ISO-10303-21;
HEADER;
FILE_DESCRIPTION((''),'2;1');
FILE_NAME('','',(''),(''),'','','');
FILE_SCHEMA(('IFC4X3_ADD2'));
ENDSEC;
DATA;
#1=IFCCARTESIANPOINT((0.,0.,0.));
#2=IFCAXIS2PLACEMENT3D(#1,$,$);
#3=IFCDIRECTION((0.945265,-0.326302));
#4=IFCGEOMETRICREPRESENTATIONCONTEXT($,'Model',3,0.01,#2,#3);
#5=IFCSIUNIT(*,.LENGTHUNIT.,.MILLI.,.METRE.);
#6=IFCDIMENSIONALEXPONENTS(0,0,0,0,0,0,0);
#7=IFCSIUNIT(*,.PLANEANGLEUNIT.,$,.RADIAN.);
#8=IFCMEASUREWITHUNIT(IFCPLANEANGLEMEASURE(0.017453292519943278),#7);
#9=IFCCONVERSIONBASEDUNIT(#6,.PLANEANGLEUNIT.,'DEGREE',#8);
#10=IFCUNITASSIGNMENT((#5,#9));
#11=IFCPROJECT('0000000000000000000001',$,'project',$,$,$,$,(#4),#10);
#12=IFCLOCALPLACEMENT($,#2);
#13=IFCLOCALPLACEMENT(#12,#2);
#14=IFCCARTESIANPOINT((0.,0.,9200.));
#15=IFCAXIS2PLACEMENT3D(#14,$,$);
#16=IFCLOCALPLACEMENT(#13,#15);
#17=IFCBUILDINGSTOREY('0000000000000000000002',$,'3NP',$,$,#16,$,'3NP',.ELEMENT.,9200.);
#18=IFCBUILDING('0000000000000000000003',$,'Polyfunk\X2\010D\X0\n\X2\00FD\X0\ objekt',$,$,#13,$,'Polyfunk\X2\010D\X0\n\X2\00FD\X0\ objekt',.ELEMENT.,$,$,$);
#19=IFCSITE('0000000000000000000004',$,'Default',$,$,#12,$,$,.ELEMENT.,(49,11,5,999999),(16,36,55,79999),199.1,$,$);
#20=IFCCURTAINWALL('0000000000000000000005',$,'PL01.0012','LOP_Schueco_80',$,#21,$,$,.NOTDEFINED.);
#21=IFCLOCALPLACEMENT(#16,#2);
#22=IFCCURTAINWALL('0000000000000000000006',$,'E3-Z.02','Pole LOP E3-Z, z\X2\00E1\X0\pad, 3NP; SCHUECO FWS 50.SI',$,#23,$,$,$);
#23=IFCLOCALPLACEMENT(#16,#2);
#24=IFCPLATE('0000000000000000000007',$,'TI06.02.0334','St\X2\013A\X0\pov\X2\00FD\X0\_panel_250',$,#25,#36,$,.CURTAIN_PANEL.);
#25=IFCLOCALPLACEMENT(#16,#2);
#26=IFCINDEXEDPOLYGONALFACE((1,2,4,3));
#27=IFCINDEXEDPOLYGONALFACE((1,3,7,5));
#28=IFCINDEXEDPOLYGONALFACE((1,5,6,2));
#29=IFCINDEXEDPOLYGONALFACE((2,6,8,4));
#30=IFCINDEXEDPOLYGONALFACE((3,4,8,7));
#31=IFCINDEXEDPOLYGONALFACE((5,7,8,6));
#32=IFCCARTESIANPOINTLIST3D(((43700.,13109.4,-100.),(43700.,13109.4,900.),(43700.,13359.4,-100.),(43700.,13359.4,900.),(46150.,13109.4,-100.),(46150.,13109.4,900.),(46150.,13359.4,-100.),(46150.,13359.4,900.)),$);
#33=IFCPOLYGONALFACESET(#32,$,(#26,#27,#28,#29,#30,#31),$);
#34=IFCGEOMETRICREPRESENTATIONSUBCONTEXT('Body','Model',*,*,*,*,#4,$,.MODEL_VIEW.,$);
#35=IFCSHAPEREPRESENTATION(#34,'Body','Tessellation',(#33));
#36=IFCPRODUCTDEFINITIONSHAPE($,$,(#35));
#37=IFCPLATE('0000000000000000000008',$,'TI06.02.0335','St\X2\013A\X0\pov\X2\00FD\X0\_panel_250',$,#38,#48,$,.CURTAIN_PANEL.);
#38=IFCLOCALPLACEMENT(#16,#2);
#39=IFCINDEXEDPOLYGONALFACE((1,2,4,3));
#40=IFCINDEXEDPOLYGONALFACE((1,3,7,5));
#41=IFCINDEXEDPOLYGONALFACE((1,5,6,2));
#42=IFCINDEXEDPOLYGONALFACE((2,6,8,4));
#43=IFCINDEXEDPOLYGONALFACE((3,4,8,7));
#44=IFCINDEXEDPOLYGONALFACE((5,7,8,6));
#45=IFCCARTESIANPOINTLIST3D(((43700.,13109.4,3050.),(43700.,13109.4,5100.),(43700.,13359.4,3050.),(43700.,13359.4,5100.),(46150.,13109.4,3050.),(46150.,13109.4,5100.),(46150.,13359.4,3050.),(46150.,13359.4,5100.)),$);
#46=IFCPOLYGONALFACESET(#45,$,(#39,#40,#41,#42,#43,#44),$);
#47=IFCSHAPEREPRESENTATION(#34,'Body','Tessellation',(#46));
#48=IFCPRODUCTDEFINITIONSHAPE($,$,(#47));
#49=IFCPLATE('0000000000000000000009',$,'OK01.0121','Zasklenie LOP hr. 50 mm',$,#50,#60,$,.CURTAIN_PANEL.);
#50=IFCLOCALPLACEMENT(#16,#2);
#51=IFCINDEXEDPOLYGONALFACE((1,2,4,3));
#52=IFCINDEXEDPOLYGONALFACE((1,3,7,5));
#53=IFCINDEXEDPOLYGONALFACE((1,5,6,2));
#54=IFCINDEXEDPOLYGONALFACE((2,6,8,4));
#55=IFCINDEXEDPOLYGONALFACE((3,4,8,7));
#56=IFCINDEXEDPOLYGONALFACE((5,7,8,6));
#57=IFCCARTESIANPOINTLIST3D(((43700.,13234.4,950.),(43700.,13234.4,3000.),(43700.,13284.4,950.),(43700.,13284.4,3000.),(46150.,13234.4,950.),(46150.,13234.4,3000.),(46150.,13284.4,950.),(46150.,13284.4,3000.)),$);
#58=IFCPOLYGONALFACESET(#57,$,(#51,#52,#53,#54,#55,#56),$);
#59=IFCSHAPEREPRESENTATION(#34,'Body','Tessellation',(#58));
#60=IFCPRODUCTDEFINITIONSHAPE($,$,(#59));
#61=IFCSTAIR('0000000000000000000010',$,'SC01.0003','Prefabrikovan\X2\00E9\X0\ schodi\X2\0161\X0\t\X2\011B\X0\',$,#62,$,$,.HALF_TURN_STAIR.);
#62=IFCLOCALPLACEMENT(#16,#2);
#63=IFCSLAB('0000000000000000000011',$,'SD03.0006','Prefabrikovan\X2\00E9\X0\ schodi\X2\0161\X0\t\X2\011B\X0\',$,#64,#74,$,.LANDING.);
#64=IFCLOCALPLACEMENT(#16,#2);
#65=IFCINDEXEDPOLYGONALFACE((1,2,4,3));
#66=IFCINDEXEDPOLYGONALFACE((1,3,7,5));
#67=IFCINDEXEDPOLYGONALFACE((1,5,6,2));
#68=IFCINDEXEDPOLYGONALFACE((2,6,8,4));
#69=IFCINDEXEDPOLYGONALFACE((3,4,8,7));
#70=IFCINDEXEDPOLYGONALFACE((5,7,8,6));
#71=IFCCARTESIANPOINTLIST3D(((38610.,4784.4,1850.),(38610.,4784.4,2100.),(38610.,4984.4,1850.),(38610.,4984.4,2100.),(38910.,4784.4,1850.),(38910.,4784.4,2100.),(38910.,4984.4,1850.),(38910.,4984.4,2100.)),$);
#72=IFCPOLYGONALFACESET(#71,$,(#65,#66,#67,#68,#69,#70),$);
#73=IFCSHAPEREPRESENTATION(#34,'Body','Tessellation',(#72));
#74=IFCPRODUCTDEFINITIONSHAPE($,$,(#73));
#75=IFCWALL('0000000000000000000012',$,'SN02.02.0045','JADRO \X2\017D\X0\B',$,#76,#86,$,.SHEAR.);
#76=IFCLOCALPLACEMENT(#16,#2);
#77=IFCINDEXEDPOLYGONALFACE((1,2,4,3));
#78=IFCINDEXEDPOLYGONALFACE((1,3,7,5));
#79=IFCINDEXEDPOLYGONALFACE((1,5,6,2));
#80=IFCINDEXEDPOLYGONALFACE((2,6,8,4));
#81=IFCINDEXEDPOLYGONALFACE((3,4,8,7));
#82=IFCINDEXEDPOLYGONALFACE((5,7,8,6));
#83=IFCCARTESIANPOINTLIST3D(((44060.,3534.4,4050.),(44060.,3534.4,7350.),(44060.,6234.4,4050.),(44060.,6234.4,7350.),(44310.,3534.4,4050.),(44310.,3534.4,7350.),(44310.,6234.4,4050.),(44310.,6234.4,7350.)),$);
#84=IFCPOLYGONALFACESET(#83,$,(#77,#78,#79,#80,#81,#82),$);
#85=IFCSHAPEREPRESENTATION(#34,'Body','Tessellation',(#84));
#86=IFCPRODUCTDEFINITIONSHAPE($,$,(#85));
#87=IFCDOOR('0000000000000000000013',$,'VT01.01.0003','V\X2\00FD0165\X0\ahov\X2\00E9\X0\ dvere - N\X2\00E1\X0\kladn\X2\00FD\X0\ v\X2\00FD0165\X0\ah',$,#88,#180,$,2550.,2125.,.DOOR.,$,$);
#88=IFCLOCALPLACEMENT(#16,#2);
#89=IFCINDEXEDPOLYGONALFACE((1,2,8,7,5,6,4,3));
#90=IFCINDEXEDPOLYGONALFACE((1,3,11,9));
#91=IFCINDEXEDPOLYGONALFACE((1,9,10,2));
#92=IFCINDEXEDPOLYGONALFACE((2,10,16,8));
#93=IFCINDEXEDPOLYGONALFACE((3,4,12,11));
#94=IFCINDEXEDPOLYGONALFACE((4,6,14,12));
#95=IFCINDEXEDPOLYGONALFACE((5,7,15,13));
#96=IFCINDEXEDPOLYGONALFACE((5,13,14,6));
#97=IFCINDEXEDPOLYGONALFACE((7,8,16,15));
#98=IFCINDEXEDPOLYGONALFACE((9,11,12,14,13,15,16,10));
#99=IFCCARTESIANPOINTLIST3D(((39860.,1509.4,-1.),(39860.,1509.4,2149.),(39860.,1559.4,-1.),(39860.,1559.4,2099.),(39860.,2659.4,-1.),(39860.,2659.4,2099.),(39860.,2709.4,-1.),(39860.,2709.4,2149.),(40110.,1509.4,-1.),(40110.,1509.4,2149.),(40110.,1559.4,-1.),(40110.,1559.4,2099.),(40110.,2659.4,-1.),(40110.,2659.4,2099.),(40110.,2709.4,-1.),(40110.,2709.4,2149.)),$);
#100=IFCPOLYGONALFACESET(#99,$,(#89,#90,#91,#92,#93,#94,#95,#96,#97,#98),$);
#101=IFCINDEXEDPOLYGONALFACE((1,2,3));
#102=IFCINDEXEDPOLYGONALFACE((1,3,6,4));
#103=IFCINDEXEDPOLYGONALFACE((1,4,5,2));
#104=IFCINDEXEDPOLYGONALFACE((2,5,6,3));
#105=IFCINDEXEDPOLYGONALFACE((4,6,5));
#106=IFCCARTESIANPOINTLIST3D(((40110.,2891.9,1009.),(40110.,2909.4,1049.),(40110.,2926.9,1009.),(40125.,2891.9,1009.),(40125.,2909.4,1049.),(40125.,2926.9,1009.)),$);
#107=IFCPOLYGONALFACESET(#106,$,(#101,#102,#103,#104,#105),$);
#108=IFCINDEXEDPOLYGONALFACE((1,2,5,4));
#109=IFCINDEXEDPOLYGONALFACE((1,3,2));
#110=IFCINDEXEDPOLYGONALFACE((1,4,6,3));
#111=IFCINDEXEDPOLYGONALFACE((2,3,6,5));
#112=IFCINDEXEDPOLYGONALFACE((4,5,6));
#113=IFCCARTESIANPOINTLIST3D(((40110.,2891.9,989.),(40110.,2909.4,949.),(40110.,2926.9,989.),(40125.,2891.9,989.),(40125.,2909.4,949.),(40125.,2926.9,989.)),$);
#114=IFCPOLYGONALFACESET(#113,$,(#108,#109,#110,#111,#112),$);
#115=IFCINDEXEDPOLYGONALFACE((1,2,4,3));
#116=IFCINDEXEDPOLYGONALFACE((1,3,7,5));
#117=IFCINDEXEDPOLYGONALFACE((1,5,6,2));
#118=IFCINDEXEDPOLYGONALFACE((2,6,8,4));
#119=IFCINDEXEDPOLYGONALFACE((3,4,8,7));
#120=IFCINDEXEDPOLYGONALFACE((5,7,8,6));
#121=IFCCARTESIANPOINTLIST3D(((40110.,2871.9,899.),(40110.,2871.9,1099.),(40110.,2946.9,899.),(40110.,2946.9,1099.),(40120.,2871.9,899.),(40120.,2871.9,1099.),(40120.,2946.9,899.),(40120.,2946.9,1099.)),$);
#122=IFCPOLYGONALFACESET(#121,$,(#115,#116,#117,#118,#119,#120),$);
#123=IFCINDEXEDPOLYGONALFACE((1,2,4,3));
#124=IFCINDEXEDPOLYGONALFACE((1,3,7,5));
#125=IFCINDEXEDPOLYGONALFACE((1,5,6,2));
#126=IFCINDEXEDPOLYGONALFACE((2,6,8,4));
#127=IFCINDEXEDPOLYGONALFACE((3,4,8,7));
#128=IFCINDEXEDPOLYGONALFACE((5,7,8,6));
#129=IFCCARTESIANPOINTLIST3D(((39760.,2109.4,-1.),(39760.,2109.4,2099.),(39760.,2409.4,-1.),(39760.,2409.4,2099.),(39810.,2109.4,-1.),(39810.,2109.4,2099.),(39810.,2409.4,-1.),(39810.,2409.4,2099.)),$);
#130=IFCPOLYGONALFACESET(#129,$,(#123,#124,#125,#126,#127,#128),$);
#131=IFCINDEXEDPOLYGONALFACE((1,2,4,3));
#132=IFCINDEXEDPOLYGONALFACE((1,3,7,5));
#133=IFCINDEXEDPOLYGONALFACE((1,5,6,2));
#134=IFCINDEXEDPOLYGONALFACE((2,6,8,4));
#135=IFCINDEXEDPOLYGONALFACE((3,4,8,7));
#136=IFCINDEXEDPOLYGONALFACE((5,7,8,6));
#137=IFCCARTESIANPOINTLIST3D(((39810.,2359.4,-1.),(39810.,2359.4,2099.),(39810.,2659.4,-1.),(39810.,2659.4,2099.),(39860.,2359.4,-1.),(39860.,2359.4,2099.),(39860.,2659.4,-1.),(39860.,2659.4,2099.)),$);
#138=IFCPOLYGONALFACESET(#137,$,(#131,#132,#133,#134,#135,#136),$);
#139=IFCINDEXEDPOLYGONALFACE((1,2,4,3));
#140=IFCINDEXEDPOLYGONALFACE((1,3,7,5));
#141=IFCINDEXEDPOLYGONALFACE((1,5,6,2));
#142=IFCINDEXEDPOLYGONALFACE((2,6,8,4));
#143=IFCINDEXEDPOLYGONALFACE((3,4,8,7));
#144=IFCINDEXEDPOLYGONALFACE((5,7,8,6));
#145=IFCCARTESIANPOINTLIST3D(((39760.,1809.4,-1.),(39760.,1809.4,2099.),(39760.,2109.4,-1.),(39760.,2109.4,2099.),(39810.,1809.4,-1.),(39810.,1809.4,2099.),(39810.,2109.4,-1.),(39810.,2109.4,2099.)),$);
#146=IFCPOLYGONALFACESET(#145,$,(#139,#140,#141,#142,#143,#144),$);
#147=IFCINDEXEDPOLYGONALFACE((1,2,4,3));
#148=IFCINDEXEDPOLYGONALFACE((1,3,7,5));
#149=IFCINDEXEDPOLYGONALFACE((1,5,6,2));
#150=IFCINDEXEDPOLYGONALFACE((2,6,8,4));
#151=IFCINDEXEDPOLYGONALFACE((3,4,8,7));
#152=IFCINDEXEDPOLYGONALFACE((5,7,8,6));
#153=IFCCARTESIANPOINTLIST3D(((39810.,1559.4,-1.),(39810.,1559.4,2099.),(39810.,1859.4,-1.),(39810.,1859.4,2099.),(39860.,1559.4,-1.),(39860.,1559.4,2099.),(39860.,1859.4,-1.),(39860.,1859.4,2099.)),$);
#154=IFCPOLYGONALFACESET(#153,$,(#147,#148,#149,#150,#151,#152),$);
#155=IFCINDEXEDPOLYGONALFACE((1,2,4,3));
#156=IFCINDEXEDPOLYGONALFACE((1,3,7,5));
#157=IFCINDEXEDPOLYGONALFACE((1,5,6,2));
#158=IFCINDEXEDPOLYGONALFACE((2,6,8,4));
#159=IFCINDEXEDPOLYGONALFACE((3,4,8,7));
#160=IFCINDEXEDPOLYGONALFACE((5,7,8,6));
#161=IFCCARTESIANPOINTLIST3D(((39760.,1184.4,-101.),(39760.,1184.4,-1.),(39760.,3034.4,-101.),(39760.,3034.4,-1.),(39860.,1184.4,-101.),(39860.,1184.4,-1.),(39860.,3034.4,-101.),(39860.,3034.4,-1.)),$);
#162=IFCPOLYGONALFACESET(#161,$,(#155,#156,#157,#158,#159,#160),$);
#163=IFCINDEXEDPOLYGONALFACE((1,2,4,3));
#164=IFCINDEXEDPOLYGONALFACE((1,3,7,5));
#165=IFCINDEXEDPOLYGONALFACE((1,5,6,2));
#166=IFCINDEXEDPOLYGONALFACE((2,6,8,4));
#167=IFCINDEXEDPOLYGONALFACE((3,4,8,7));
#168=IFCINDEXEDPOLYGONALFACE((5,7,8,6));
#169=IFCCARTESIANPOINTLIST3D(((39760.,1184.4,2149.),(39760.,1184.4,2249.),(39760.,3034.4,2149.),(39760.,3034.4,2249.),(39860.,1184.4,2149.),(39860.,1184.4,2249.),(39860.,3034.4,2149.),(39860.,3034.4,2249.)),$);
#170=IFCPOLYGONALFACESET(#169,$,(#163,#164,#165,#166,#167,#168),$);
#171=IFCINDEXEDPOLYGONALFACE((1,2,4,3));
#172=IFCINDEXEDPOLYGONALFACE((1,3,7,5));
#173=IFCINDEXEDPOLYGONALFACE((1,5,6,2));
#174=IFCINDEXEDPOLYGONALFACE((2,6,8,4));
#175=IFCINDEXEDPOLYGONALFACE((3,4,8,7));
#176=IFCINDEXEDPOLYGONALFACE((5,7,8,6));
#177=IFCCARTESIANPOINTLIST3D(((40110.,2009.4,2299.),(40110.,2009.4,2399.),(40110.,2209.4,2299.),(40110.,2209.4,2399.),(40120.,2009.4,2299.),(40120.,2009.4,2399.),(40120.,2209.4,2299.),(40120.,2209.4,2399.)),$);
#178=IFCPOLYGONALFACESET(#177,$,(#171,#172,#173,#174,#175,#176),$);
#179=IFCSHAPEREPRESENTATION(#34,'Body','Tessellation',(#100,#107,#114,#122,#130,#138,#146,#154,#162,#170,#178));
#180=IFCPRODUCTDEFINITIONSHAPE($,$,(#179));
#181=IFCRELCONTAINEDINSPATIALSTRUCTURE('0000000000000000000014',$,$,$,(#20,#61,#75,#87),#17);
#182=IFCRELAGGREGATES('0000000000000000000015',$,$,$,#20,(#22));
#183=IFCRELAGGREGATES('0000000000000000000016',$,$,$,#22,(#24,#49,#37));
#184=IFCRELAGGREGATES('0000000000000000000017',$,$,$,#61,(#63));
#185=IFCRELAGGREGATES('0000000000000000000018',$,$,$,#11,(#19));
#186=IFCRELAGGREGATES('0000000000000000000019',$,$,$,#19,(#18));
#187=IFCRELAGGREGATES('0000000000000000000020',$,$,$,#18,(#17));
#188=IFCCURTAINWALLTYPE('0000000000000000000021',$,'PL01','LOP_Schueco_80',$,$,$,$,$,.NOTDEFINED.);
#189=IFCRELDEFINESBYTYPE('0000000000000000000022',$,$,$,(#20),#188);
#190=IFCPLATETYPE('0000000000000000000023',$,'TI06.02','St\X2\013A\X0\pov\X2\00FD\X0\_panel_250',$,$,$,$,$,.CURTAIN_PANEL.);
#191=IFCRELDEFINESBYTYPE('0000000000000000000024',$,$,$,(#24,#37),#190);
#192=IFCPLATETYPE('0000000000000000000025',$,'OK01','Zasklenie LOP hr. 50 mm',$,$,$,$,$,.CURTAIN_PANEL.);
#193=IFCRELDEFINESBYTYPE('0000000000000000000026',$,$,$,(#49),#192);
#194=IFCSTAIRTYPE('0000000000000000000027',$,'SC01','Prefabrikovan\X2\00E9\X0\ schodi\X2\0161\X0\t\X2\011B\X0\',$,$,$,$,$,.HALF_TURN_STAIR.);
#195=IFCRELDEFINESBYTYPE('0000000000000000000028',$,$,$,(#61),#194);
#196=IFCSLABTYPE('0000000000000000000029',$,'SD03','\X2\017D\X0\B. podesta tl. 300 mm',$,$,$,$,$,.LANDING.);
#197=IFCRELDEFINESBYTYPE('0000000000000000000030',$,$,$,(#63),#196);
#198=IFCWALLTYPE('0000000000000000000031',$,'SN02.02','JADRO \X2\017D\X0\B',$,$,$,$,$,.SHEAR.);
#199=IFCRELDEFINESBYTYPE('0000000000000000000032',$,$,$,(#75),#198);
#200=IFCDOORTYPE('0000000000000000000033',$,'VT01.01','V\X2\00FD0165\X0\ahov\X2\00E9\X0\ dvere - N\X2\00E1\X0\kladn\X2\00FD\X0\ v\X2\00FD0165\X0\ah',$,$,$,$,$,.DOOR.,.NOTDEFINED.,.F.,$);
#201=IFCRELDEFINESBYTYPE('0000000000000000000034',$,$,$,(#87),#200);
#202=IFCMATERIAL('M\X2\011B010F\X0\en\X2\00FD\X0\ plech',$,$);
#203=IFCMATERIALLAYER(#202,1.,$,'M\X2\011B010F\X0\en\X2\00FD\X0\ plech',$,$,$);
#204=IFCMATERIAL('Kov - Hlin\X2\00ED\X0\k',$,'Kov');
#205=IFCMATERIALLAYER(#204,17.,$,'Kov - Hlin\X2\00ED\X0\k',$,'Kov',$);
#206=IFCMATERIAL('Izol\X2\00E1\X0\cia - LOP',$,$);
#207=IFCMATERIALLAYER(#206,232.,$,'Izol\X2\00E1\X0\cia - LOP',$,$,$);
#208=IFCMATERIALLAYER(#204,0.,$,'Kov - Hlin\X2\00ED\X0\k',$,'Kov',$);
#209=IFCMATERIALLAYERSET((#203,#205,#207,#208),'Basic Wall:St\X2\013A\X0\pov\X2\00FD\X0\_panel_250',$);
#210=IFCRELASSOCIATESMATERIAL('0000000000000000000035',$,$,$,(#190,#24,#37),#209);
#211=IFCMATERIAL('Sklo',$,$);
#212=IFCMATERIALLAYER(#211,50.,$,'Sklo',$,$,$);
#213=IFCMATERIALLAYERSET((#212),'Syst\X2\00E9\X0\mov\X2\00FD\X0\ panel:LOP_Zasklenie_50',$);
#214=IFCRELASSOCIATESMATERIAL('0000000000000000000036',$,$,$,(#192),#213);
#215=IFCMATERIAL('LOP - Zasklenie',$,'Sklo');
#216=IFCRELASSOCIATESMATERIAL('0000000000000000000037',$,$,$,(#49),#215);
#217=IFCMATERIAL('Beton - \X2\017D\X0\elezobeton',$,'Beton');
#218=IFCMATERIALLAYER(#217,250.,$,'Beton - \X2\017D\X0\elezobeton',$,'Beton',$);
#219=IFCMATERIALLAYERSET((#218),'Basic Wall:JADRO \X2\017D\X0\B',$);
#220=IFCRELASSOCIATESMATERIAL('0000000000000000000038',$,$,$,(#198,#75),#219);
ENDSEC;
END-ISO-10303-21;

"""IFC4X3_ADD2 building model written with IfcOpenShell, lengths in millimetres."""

from ifc_helpers import new_model, entity, si_unit, converted_unit, direction, frame, frame_2d, origin, origin_2d_with_axis, place, context, subcontext, project, spatial, polyline, rectangle, outline, extrude, clip, bounded_halfspace, source, transform, mapped, material, layer, layer_set, layer_usage, type_object, type_shapes, element, aggregate, save


model = new_model("IFC4X3_ADD2")

# Units and contexts
model_context = context("Model", 3, precision=0.01, world=origin(), true_north=direction((0.945265, -0.326302)))
body_context = subcontext(model_context, "Body", "Model", "MODEL_VIEW")
ifc_project = project(units=[si_unit("LENGTHUNIT", "METRE", prefix="MILLI"), converted_unit("PLANEANGLEUNIT", "DEGREE", entity("IfcPlaneAngleMeasure", 0.017453292519943278), si_unit("PLANEANGLEUNIT", "RADIAN"), dimensions=[0, 0, 0, 0, 0, 0, 0])], contexts=[model_context])

# Site, building, storey
site_placement = place(None, origin())
site = spatial("IfcSite", under=ifc_project, at=site_placement, Name="Default", CompositionType="ELEMENT", RefLatitude=(49, 11, 5, 999999), RefLongitude=(16, 36, 55, 79999), RefElevation=199.1)
building_placement = place(site_placement, origin())
building = spatial("IfcBuilding", under=site, at=building_placement, Name="Polyfunkčný objekt", LongName="Polyfunkčný objekt", CompositionType="ELEMENT")
storey_placement = place(building_placement, frame((0.0, 0.0, 9200.0)))
storey = spatial("IfcBuildingStorey", under=building, at=storey_placement, Name="3NP", LongName="3NP", CompositionType="ELEMENT", Elevation=9200.0)

# Curtain walls, plates
curtain_wall_type = type_object("IfcCurtainWallType", Name="PL01", Description="LOP_Schueco_80", PredefinedType="NOTDEFINED")
curtain_wall_1_placement = place(storey_placement, frame((0.0, 0.0, -9200.0)))
curtain_wall_1 = element("IfcCurtainWall", 1, at=curtain_wall_1_placement, inside=storey, type_object=curtain_wall_type, Name="PL01.0012", Description="LOP_Schueco_80", PredefinedType="NOTDEFINED")
curtain_wall_2 = element("IfcCurtainWall", 2, Name="E3-Z.02", Description="Pole LOP E3-Z, západ, 3NP; SCHUECO FWS 50.SI")
aggregate(curtain_wall_1, [curtain_wall_2])
ifc_material_1 = material(Name="Měďený plech")
ifc_layer_1 = layer(ifc_material_1, 1.0, Name="Měďený plech")
ifc_material_2 = material(Name="Kov - Hliník", Category="Kov")
ifc_layer_2 = layer(ifc_material_2, 17.0, Name="Kov - Hliník", Category="Kov")
ifc_material_3 = material(Name="Izolácia - LOP")
ifc_layer_3 = layer(ifc_material_3, 232.0, Name="Izolácia - LOP")
ifc_layer_4 = layer(ifc_material_2, 0.0, Name="Kov - Hliník", Category="Kov")
ifc_layer_set_1 = layer_set([ifc_layer_1, ifc_layer_2, ifc_layer_3, ifc_layer_4], Name="Basic Wall:Stĺpový_panel_250")
ifc_layer_usage_1 = layer_usage(ifc_layer_set_1, "AXIS2", "NEGATIVE", 125.0)
plate_type_1 = type_object("IfcPlateType", Name="TI06.02", Description="Stĺpový_panel_250", PredefinedType="CURTAIN_PANEL", material=ifc_layer_set_1)
plate_1_placement = place(storey_placement, frame((43700.0, 13234.4, -100.0)))
plate_1 = element("IfcPlate", 3, at=plate_1_placement, type_object=plate_type_1, material=ifc_layer_usage_1, Name="TI06.02.0334", Description="Stĺpový_panel_250", PredefinedType="CURTAIN_PANEL", context=body_context, shape_type="SweptSolid", body=[
    extrude(rectangle(XDim=250.0, YDim=2450.0, at=frame_2d((0.0, 0.0), x_axis=(1.0, 0.0))), frame((1225.0, 0.0, 0.0), z_axis=(0.0, 0.0, 1.0), x_axis=(0.0, 1.0, 0.0)), (0.0, 0.0, 1.0), 1000.0),
])
ifc_layer_usage_2 = layer_usage(ifc_layer_set_1, "AXIS2", "NEGATIVE", 125.0)
plate_2_placement = place(storey_placement, frame((43700.0, 13234.4, 3050.0)))
plate_2 = element("IfcPlate", 4, at=plate_2_placement, type_object=plate_type_1, material=ifc_layer_usage_2, Name="TI06.02.0335", Description="Stĺpový_panel_250", PredefinedType="CURTAIN_PANEL", context=body_context, shape_type="SweptSolid", body=[
    extrude(rectangle(XDim=250.0, YDim=2450.0, at=frame_2d((0.0, 0.0), x_axis=(1.0, 0.0))), frame((1225.0, 0.0, 0.0), z_axis=(0.0, 0.0, 1.0), x_axis=(0.0, 1.0, 0.0)), (0.0, 0.0, 1.0), 2050.0),
])
ifc_material_4 = material(Name="LOP - Zasklenie", Category="Sklo")
ifc_material_5 = material(Name="Sklo")
ifc_layer_5 = layer(ifc_material_5, 50.0, Name="Sklo")
ifc_layer_set_2 = layer_set([ifc_layer_5], Name="Systémový panel:LOP_Zasklenie_50")
plate_type_2 = type_object("IfcPlateType", Name="OK01", Description="Zasklenie LOP hr. 50 mm", PredefinedType="CURTAIN_PANEL", material=ifc_layer_set_2)
shared_shape_1 = source(origin(), body_context, "Body", "SweptSolid", [
    extrude(rectangle(XDim=50.0, YDim=2450.0, at=origin_2d_with_axis()), frame((0.0, 25.0, 0.0), z_axis=(0.0, 0.0, 1.0), x_axis=(0.0, 1.0, 0.0)), (0.0, 0.0, 1.0), 2050.0),
])
type_shapes(plate_type_2, [shared_shape_1])
plate_3_placement = place(curtain_wall_1_placement, frame((44925.0, 13234.4, 10150.0)))
plate_3 = element("IfcPlate", 5, at=plate_3_placement, type_object=plate_type_2, material=ifc_material_4, Name="OK01.0121", Description="Zasklenie LOP hr. 50 mm", PredefinedType="CURTAIN_PANEL", context=body_context, shape_type="MappedRepresentation", body=[
    mapped(shared_shape_1, transform((0.0, 0.0, 0.0), scale=1.0)),
])
aggregate(curtain_wall_2, [plate_1, plate_3, plate_2])

# Stair, slab
stair_type = type_object("IfcStairType", Name="SC01", Description="Prefabrikované schodiště", PredefinedType="HALF_TURN_STAIR")
stair_placement = place(storey_placement, origin())
stair = element("IfcStair", 6, at=stair_placement, inside=storey, type_object=stair_type, Name="SC01.0003", Description="Prefabrikované schodiště", PredefinedType="HALF_TURN_STAIR")
slab_type = type_object("IfcSlabType", Name="SD03", Description="ŽB. podesta tl. 300 mm", PredefinedType="LANDING")
slab_placement = place(stair_placement, frame((38610.0, 4784.4, 0.0)))
slab = element("IfcSlab", 7, at=slab_placement, type_object=slab_type, Name="SD03.0006", Description="Prefabrikované schodiště", PredefinedType="LANDING", context=body_context, shape_type="SweptSolid", body=[
    extrude(rectangle(XDim=200.0, YDim=300.0, at=frame_2d((0.0, 0.0), x_axis=(1.0, 0.0))), frame((150.0, 100.0, 1850.0), z_axis=(0.0, 0.0, 1.0), x_axis=(0.0, 1.0, 0.0)), (0.0, 0.0, 1.0), 250.0),
])
aggregate(stair, [slab])

# Wall
ifc_material_6 = material(Name="Beton - Železobeton", Category="Beton")
ifc_layer_6 = layer(ifc_material_6, 250.0, Name="Beton - Železobeton", Category="Beton")
ifc_layer_set_3 = layer_set([ifc_layer_6], Name="Basic Wall:JADRO ŽB")
wall_type = type_object("IfcWallType", Name="SN02.02", Description="JADRO ŽB", PredefinedType="SHEAR", material=ifc_layer_set_3)
wall_placement = place(storey_placement, frame((44185.0, 6234.4, 4050.0), z_axis=(0.0, 0.0, 1.0), x_axis=(0.0, -1.0, 0.0)))
element("IfcWall", 8, at=wall_placement, inside=storey, type_object=wall_type, material=ifc_layer_set_3, Name="SN02.02.0045", Description="JADRO ŽB", PredefinedType="SHEAR", context=body_context, shape_type="Clipping", body=[
    clip(clip(extrude(rectangle(XDim=2700.0, YDim=250.0, at=frame_2d((1350.0, 0.0), x_axis=(-1.0, 0.0))), origin(), (0.0, 0.0, 1.0), 3300.0), bounded_halfspace(frame((2700.0, -125.0, 0.0), z_axis=(0.0, 0.0, 1.0), x_axis=(0.0, -1.0, 0.0)), True, frame((2700.0, -125.0, 0.0)), polyline([(0.0, 0.0), (0.0, 250.0), (-2700.0, 250.0), (-2700.0, 0.0), (0.0, 0.0)]))), bounded_halfspace(frame((0.0, -125.0, 3300.0), z_axis=(0.0, 0.0, -1.0), x_axis=(1.0, 0.0, 0.0)), True, frame((0.0, -125.0, 3300.0)), polyline([(0.0, 0.0), (2700.0, 0.0), (2700.0, 250.0), (0.0, 250.0), (0.0, 0.0)]))),
])

# Door
door_type_1 = type_object("IfcDoorType", Name="VT01.01", Description="Výťahové dvere - Nákladný výťah", OperationType="NOTDEFINED", ParameterTakesPrecedence=False, PredefinedType="DOOR")
shared_shape_2 = source(origin(), body_context, "Body", "SweptSolid", [
    extrude(outline(polyline([(-1087.5, -600.0), (1062.5, -600.0), (1062.5, -550.0), (-1037.5, -550.0), (-1037.5, 550.0), (1062.5, 550.0), (1062.5, 600.0), (-1087.5, 600.0), (-1087.5, -600.0)])), frame((600.0, 0.0, 1062.5), z_axis=(0.0, 1.0, 0.0), x_axis=(0.0, 0.0, -1.0)), (0.0, 0.0, 1.0), 250.0),
    extrude(outline(polyline([(-24.4, -10.7), (19.2, -10.7), (5.2, 21.4), (-24.4, -10.7)])), frame((1400.0, -15.0, 1023.3), z_axis=(0.0, 1.0, 0.0), x_axis=(0.400819, 0.0, -0.916157)), (0.0, 0.0, 1.0), 15.0),
    extrude(outline(polyline([(-24.4, -10.7), (19.2, -10.7), (5.2, 21.4), (-24.4, -10.7)])), frame((1400.0, -15.0, 976.7), z_axis=(0.0, 1.0, 0.0), x_axis=(-0.400819, 0.0, 0.916157)), (0.0, 0.0, 1.0), 15.0),
    extrude(rectangle(XDim=10.0, YDim=75.0, at=frame_2d((0.0, 0.0), x_axis=(1.0, 0.0))), frame((1400.0, -5.0, 900.0), z_axis=(0.0, 0.0, 1.0), x_axis=(0.0, 1.0, 0.0)), (0.0, 0.0, 1.0), 200.0),
    extrude(rectangle(XDim=50.0, YDim=300.0, at=origin_2d_with_axis()), frame((750.0, 325.0, 0.0), z_axis=(0.0, 0.0, 1.0), x_axis=(0.0, -1.0, 0.0)), (0.0, 0.0, 1.0), 2100.0),
    extrude(rectangle(XDim=50.0, YDim=300.0, at=frame_2d((0.0, 0.0), x_axis=(1.0, 0.0))), frame((1000.0, 275.0, 0.0), z_axis=(0.0, 0.0, 1.0), x_axis=(0.0, -1.0, 0.0)), (0.0, 0.0, 1.0), 2100.0),
    extrude(rectangle(XDim=300.0, YDim=50.0, at=frame_2d((0.0, 0.0), x_axis=(1.0, 0.0))), frame((450.0, 325.0, 0.0), z_axis=(0.0, 0.0, 1.0), x_axis=(-1.0, 0.0, 0.0)), (0.0, 0.0, 1.0), 2100.0),
    extrude(rectangle(XDim=300.0, YDim=50.0, at=frame_2d((0.0, 0.0), x_axis=(1.0, 0.0))), frame((200.0, 275.0, 0.0), z_axis=(0.0, 0.0, 1.0), x_axis=(-1.0, 0.0, 0.0)), (0.0, 0.0, 1.0), 2100.0),
    extrude(rectangle(XDim=1850.0, YDim=100.0, at=frame_2d((0.0, 0.0), x_axis=(1.0, 0.0))), frame((600.0, 300.0, -100.0), z_axis=(0.0, 0.0, 1.0), x_axis=(-1.0, 0.0, 0.0)), (0.0, 0.0, 1.0), 100.0),
    extrude(rectangle(XDim=1850.0, YDim=100.0, at=frame_2d((0.0, 0.0), x_axis=(1.0, 0.0))), frame((600.0, 300.0, 2150.0), z_axis=(0.0, 0.0, 1.0), x_axis=(-1.0, 0.0, 0.0)), (0.0, 0.0, 1.0), 100.0),
    extrude(rectangle(XDim=10.0, YDim=200.0, at=frame_2d((0.0, 0.0), x_axis=(1.0, 0.0))), frame((600.0, -5.0, 2300.0), z_axis=(0.0, 0.0, 1.0), x_axis=(0.0, 1.0, 0.0)), (0.0, 0.0, 1.0), 100.0),
])
type_shapes(door_type_1, [shared_shape_2])
door_1_placement = place(storey_placement, frame((40110.0, 1509.4, -1.0), z_axis=(0.0, 0.0, 1.0), x_axis=(0.0, 1.0, 0.0)))
element("IfcDoor", 9, at=door_1_placement, inside=storey, type_object=door_type_1, Name="VT01.01.0003", Description="Výťahové dvere - Nákladný výťah", OverallHeight=2550.0, OverallWidth=2125.0, PredefinedType="DOOR", context=body_context, shape_type="MappedRepresentation", body=[
    mapped(shared_shape_2, transform((0.0, 0.0, 0.0), scale=1.0)),
])

save(model, "model.ifc")
